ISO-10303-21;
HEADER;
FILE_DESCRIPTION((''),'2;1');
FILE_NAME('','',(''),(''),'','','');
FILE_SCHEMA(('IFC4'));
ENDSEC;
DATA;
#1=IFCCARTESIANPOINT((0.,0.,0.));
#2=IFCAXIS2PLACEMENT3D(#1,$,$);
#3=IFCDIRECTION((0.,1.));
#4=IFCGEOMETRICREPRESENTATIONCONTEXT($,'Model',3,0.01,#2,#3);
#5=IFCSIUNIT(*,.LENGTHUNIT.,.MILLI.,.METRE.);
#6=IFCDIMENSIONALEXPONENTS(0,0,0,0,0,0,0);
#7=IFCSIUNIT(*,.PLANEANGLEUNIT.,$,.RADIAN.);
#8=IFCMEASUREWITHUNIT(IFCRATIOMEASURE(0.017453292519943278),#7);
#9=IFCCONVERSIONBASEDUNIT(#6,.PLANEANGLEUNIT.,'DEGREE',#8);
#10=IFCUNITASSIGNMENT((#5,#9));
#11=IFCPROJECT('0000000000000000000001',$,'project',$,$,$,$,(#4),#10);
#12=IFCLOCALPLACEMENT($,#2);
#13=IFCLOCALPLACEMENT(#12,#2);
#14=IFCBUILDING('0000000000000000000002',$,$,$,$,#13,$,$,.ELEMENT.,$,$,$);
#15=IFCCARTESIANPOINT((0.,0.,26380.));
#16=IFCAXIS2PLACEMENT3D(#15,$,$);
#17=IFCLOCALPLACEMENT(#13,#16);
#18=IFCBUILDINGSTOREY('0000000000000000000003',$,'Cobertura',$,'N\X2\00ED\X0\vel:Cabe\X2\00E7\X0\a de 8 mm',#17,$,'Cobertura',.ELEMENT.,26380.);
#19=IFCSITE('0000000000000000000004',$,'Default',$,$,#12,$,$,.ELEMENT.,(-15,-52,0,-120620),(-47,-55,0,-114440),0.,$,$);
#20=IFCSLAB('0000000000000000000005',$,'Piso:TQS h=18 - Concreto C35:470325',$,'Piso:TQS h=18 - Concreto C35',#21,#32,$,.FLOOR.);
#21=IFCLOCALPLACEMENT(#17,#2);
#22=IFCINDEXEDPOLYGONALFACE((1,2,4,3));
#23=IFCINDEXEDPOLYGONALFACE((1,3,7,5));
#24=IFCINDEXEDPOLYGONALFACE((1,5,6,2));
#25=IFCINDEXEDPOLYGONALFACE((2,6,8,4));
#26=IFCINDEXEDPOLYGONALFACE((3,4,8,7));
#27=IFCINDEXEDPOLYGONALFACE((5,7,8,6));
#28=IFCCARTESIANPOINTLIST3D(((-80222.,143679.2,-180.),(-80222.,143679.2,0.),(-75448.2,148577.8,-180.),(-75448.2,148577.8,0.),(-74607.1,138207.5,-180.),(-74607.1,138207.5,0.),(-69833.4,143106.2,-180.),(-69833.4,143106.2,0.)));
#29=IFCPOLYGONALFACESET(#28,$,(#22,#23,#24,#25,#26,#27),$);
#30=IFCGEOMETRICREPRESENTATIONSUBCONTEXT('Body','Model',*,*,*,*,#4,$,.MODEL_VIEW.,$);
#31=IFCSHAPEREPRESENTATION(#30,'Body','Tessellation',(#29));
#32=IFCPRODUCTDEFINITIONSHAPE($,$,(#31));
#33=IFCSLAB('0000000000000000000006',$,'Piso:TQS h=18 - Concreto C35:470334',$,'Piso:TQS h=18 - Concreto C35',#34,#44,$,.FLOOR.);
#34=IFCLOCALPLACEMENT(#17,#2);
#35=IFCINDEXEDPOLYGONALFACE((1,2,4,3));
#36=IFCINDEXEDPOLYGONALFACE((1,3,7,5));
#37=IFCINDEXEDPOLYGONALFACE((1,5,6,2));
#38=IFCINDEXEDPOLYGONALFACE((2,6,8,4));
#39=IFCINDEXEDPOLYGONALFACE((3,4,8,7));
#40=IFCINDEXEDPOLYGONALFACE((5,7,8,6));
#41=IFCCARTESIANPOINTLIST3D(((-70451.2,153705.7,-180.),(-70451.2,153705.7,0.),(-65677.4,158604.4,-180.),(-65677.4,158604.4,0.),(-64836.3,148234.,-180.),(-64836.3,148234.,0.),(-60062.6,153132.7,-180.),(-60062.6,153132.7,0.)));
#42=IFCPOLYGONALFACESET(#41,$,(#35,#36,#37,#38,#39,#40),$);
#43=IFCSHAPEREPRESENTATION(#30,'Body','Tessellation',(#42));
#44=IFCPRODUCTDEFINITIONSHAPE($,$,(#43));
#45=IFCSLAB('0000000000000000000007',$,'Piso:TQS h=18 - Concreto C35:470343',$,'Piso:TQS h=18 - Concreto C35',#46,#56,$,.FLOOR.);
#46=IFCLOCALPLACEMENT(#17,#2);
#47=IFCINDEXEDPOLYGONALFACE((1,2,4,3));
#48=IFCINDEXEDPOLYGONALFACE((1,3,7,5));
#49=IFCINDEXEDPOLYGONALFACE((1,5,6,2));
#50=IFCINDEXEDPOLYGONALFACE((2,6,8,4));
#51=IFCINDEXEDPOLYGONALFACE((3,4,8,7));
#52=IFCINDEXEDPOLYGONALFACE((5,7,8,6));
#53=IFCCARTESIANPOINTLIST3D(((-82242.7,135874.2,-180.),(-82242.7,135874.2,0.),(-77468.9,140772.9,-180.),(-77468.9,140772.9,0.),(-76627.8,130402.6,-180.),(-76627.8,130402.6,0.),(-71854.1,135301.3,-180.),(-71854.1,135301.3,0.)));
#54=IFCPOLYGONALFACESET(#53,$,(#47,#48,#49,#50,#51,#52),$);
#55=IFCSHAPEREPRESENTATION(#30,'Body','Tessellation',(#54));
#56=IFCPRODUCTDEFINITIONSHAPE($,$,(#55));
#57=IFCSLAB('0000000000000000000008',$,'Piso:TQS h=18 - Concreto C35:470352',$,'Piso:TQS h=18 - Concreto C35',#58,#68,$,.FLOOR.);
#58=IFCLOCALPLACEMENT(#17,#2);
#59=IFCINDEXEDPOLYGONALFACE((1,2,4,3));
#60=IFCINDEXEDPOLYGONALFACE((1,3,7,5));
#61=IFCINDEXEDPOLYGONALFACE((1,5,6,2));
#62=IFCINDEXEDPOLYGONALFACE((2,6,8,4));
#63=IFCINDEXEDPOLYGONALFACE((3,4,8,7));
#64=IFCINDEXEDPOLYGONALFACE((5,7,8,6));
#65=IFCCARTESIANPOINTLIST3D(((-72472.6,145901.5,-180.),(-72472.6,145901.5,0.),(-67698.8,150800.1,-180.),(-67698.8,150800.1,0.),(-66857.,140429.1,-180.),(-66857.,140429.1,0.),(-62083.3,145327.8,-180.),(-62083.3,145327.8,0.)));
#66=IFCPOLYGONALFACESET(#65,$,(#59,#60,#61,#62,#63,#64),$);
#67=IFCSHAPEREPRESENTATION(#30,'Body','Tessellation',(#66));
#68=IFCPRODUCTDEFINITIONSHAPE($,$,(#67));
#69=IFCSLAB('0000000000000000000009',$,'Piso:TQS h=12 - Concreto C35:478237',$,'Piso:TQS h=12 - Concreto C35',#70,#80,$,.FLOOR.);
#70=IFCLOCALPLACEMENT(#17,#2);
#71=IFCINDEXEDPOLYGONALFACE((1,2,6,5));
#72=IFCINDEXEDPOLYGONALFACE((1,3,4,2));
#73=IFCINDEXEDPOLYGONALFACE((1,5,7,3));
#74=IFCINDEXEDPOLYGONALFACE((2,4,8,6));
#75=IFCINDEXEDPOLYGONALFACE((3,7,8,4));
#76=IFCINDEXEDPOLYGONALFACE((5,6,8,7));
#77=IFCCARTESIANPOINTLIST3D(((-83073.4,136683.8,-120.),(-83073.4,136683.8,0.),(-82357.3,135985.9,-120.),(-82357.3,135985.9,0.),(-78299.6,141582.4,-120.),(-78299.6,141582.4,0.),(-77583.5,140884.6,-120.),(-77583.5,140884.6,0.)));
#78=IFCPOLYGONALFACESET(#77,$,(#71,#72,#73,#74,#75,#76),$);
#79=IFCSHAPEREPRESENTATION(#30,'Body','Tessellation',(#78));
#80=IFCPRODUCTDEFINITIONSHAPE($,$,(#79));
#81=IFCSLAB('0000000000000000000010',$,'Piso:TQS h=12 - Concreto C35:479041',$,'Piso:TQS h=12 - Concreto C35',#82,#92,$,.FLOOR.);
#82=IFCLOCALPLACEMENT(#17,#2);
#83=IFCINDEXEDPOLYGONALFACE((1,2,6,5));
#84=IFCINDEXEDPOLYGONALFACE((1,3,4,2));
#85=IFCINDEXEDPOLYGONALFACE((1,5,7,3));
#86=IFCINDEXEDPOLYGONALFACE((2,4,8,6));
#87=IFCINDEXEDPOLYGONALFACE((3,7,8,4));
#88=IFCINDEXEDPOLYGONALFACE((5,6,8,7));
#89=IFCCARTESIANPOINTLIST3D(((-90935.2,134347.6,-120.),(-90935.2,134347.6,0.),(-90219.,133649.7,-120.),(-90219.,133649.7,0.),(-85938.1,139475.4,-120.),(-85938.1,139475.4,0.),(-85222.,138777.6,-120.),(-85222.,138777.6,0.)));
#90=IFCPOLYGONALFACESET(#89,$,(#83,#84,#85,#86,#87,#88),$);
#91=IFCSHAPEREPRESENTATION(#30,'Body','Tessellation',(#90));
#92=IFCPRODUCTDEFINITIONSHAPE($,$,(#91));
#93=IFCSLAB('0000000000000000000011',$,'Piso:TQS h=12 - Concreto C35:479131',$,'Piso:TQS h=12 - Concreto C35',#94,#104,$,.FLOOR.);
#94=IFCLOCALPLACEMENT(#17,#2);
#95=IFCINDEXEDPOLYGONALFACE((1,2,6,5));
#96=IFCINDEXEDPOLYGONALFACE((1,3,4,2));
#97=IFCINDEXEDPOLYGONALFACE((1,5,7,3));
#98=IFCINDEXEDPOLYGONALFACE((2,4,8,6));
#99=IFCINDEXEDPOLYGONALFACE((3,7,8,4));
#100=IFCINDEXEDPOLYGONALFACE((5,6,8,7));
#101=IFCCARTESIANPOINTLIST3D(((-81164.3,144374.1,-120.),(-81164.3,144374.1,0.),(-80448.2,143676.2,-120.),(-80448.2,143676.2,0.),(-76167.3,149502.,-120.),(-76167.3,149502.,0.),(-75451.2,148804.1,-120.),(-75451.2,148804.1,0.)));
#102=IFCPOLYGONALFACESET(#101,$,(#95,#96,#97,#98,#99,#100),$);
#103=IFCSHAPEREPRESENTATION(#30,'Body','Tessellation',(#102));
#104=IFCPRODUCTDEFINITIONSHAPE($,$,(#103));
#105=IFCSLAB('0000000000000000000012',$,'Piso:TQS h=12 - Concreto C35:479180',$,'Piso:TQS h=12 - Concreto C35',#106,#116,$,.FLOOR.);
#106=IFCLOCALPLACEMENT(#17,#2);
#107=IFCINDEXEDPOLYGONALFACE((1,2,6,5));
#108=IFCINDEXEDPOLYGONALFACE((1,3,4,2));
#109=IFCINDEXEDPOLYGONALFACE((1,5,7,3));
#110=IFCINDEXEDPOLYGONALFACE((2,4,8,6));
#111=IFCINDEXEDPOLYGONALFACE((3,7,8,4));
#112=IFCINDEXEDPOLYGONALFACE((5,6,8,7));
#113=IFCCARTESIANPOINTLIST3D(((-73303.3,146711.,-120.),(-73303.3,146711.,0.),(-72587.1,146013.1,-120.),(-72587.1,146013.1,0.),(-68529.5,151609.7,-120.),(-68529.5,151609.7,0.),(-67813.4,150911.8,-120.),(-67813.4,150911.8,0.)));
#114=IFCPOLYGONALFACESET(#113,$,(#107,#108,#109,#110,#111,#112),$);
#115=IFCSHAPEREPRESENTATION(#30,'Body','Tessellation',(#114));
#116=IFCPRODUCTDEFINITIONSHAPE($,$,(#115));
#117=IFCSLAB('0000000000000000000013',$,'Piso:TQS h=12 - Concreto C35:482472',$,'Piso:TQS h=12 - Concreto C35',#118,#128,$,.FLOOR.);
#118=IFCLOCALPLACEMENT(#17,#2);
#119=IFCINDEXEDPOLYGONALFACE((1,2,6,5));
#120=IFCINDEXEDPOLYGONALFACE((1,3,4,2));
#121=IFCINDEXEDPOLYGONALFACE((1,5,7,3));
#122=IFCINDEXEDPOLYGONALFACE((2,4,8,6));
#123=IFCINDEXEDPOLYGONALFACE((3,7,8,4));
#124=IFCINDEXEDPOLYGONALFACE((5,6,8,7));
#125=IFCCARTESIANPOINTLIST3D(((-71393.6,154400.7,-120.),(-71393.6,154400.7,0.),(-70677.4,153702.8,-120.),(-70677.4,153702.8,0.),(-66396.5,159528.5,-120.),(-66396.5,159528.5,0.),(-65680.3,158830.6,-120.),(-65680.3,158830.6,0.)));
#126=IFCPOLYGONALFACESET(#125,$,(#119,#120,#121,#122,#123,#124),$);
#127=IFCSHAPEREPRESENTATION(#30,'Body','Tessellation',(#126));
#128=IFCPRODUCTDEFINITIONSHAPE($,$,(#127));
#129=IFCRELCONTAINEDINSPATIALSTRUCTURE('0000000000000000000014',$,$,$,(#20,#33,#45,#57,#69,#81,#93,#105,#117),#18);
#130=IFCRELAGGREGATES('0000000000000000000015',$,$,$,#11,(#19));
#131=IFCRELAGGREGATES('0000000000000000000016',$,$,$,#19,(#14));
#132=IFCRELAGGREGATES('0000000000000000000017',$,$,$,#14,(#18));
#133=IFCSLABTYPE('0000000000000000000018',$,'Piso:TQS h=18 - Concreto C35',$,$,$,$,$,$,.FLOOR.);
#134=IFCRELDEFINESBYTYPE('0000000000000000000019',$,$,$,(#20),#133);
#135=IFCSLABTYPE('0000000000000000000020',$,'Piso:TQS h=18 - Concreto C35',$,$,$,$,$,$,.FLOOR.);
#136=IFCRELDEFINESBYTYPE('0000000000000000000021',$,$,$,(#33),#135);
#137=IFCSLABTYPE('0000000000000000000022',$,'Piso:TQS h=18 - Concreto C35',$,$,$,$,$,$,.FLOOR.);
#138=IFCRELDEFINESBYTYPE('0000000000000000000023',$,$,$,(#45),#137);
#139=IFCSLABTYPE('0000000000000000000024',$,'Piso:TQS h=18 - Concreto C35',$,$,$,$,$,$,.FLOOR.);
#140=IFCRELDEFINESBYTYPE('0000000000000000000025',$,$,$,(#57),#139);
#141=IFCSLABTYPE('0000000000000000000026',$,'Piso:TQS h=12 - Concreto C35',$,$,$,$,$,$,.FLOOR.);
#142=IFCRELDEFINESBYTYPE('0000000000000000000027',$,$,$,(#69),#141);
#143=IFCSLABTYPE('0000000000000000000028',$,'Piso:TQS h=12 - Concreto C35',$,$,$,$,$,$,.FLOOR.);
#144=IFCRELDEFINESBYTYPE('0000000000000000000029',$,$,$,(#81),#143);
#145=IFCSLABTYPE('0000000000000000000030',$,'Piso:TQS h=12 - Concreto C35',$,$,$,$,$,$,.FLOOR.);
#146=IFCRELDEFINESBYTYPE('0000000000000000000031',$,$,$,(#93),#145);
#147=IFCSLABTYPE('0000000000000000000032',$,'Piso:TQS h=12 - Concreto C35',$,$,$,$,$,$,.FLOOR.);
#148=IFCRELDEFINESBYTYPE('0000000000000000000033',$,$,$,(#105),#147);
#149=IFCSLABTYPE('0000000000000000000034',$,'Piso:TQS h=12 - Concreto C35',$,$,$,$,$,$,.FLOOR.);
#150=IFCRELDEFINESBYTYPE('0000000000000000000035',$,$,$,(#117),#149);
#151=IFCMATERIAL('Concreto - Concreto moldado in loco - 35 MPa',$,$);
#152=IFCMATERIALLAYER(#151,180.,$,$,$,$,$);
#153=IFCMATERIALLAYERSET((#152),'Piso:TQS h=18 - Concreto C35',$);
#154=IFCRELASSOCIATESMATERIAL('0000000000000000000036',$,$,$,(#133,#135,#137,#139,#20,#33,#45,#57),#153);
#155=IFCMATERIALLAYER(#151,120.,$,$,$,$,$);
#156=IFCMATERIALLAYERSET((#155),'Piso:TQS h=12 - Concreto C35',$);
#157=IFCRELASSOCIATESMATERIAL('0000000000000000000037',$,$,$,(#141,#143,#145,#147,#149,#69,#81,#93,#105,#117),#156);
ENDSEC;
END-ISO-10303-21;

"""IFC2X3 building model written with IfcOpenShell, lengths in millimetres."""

from ifc_helpers import new_model, entity, si_unit, converted_unit, direction, frame, frame_2d, origin, place, context, subcontext, project, spatial, rectangle, extrude, material, layer, layer_set, layer_usage, type_object, element, save


model = new_model("IFC2X3")

# Units and contexts
model_context = context("Model", 3, precision=0.01, world=origin(), true_north=direction((0.0, 1.0)))
body_context = subcontext(model_context, "Body", "Model", "MODEL_VIEW")
ifc_project = project(units=[si_unit("LENGTHUNIT", "METRE", prefix="MILLI"), converted_unit("PLANEANGLEUNIT", "DEGREE", entity("IfcRatioMeasure", 0.017453292519943278), si_unit("PLANEANGLEUNIT", "RADIAN"), dimensions=[0, 0, 0, 0, 0, 0, 0])], contexts=[model_context])

# Site, building, storey
site_placement = place(None, origin())
site = spatial("IfcSite", under=ifc_project, at=site_placement, Name="Default", CompositionType="ELEMENT", RefLatitude=(-15, -52, 0, -120620), RefLongitude=(-47, -55, 0, -114440), RefElevation=0.0)
building_placement = place(site_placement, origin())
building = spatial("IfcBuilding", under=site, at=building_placement, CompositionType="ELEMENT")
storey_placement = place(building_placement, frame((0.0, 0.0, 26380.0)))
storey = spatial("IfcBuildingStorey", under=building, at=storey_placement, Name="Cobertura", ObjectType="Nível:Cabeça de 8 mm", LongName="Cobertura", CompositionType="ELEMENT", Elevation=26380.0)

# Shared definitions
ifc_material = material(Name="Concreto - Concreto moldado in loco - 35 MPa")

# Slabs
ifc_layer_1 = layer(ifc_material, 180.0)
ifc_layer_set_1 = layer_set([ifc_layer_1], Name="Piso:TQS h=18 - Concreto C35")
ifc_layer_usage_1 = layer_usage(ifc_layer_set_1, "AXIS3", "POSITIVE", 0.0)
slab_type_1 = type_object("IfcSlabType", Name="Piso:TQS h=18 - Concreto C35", PredefinedType="FLOOR", material=ifc_layer_set_1)
slab_1_placement = place(storey_placement, origin())
element("IfcSlab", 1, at=slab_1_placement, inside=storey, type_object=slab_type_1, material=ifc_layer_usage_1, Name="Piso:TQS h=18 - Concreto C35:470325", ObjectType="Piso:TQS h=18 - Concreto C35", PredefinedType="FLOOR", context=body_context, shape_type="SweptSolid", body=[
    extrude(rectangle(XDim=6840.0, YDim=7840.0, at=frame_2d((0.0, 0.0), x_axis=(1.0, 0.0))), frame((-75027.7, 143392.7, 0.0), z_axis=(0.0, 0.0, -1.0), x_axis=(-0.697915, -0.71618, 0.0)), (0.0, 0.0, 1.0), 180.0),
])
ifc_layer_usage_2 = layer_usage(ifc_layer_set_1, "AXIS3", "POSITIVE", 0.0)
slab_type_2 = type_object("IfcSlabType", Name="Piso:TQS h=18 - Concreto C35", PredefinedType="FLOOR", material=ifc_layer_set_1)
slab_2_placement = place(storey_placement, origin())
element("IfcSlab", 2, at=slab_2_placement, inside=storey, type_object=slab_type_2, material=ifc_layer_usage_2, Name="Piso:TQS h=18 - Concreto C35:470334", ObjectType="Piso:TQS h=18 - Concreto C35", PredefinedType="FLOOR", context=body_context, shape_type="SweptSolid", body=[
    extrude(rectangle(XDim=7840.0, YDim=6840.0, at=frame_2d((0.0, 0.0), x_axis=(1.0, 0.0))), frame((-65256.9, 153419.2, 0.0), z_axis=(0.0, 0.0, -1.0), x_axis=(0.71618, -0.697915, 0.0)), (0.0, 0.0, 1.0), 180.0),
])
ifc_layer_usage_3 = layer_usage(ifc_layer_set_1, "AXIS3", "POSITIVE", 0.0)
slab_type_3 = type_object("IfcSlabType", Name="Piso:TQS h=18 - Concreto C35", PredefinedType="FLOOR", material=ifc_layer_set_1)
slab_3_placement = place(storey_placement, origin())
element("IfcSlab", 3, at=slab_3_placement, inside=storey, type_object=slab_type_3, material=ifc_layer_usage_3, Name="Piso:TQS h=18 - Concreto C35:470343", ObjectType="Piso:TQS h=18 - Concreto C35", PredefinedType="FLOOR", context=body_context, shape_type="SweptSolid", body=[
    extrude(rectangle(XDim=6840.0, YDim=7840.0, at=frame_2d((0.0, 0.0), x_axis=(1.0, 0.0))), frame((-77048.4, 135587.8, 0.0), z_axis=(0.0, 0.0, -1.0), x_axis=(-0.697915, -0.71618, 0.0)), (0.0, 0.0, 1.0), 180.0),
])
ifc_layer_usage_4 = layer_usage(ifc_layer_set_1, "AXIS3", "POSITIVE", 0.0)
slab_type_4 = type_object("IfcSlabType", Name="Piso:TQS h=18 - Concreto C35", PredefinedType="FLOOR", material=ifc_layer_set_1)
slab_4_placement = place(storey_placement, origin())
element("IfcSlab", 4, at=slab_4_placement, inside=storey, type_object=slab_type_4, material=ifc_layer_usage_4, Name="Piso:TQS h=18 - Concreto C35:470352", ObjectType="Piso:TQS h=18 - Concreto C35", PredefinedType="FLOOR", context=body_context, shape_type="SweptSolid", body=[
    extrude(rectangle(XDim=7841.0, YDim=6840.0, at=frame_2d((0.0, 0.0), x_axis=(1.0, 0.0))), frame((-67277.9, 145614.6, 0.0), z_axis=(0.0, 0.0, -1.0), x_axis=(0.71618, -0.697915, 0.0)), (0.0, 0.0, 1.0), 180.0),
])
ifc_layer_2 = layer(ifc_material, 120.0)
ifc_layer_set_2 = layer_set([ifc_layer_2], Name="Piso:TQS h=12 - Concreto C35")
ifc_layer_usage_5 = layer_usage(ifc_layer_set_2, "AXIS3", "POSITIVE", 0.0)
slab_type_5 = type_object("IfcSlabType", Name="Piso:TQS h=12 - Concreto C35", PredefinedType="FLOOR", material=ifc_layer_set_2)
slab_5_placement = place(storey_placement, origin())
element("IfcSlab", 5, at=slab_5_placement, inside=storey, type_object=slab_type_5, material=ifc_layer_usage_5, Name="Piso:TQS h=12 - Concreto C35:478237", ObjectType="Piso:TQS h=12 - Concreto C35", PredefinedType="FLOOR", context=body_context, shape_type="SweptSolid", body=[
    extrude(rectangle(XDim=6840.0, YDim=999.9, at=frame_2d((0.0, 0.0), x_axis=(1.0, 0.0))), frame((-80328.4, 138784.2, 0.0), z_axis=(0.0, 0.0, -1.0), x_axis=(-0.697915, -0.71618, 0.0)), (0.0, 0.0, 1.0), 120.0),
])
ifc_layer_usage_6 = layer_usage(ifc_layer_set_2, "AXIS3", "POSITIVE", 0.0)
slab_type_6 = type_object("IfcSlabType", Name="Piso:TQS h=12 - Concreto C35", PredefinedType="FLOOR", material=ifc_layer_set_2)
slab_6_placement = place(storey_placement, origin())
element("IfcSlab", 6, at=slab_6_placement, inside=storey, type_object=slab_type_6, material=ifc_layer_usage_6, Name="Piso:TQS h=12 - Concreto C35:479041", ObjectType="Piso:TQS h=12 - Concreto C35", PredefinedType="FLOOR", context=body_context, shape_type="SweptSolid", body=[
    extrude(rectangle(XDim=7160.0, YDim=999.9, at=frame_2d((0.0, 0.0), x_axis=(1.0, 0.0))), frame((-88078.6, 136562.6, 0.0), z_axis=(0.0, 0.0, -1.0), x_axis=(-0.697915, -0.71618, 0.0)), (0.0, 0.0, 1.0), 120.0),
])
ifc_layer_usage_7 = layer_usage(ifc_layer_set_2, "AXIS3", "POSITIVE", 0.0)
slab_type_7 = type_object("IfcSlabType", Name="Piso:TQS h=12 - Concreto C35", PredefinedType="FLOOR", material=ifc_layer_set_2)
slab_7_placement = place(storey_placement, origin())
element("IfcSlab", 7, at=slab_7_placement, inside=storey, type_object=slab_type_7, material=ifc_layer_usage_7, Name="Piso:TQS h=12 - Concreto C35:479131", ObjectType="Piso:TQS h=12 - Concreto C35", PredefinedType="FLOOR", context=body_context, shape_type="SweptSolid", body=[
    extrude(rectangle(XDim=7160.0, YDim=999.9, at=frame_2d((0.0, 0.0), x_axis=(1.0, 0.0))), frame((-78307.8, 146589.1, 0.0), z_axis=(0.0, 0.0, -1.0), x_axis=(-0.697915, -0.71618, 0.0)), (0.0, 0.0, 1.0), 120.0),
])
ifc_layer_usage_8 = layer_usage(ifc_layer_set_2, "AXIS3", "POSITIVE", 0.0)
slab_type_8 = type_object("IfcSlabType", Name="Piso:TQS h=12 - Concreto C35", PredefinedType="FLOOR", material=ifc_layer_set_2)
slab_8_placement = place(storey_placement, origin())
element("IfcSlab", 8, at=slab_8_placement, inside=storey, type_object=slab_type_8, material=ifc_layer_usage_8, Name="Piso:TQS h=12 - Concreto C35:479180", ObjectType="Piso:TQS h=12 - Concreto C35", PredefinedType="FLOOR", context=body_context, shape_type="SweptSolid", body=[
    extrude(rectangle(XDim=6840.0, YDim=999.9, at=frame_2d((0.0, 0.0), x_axis=(1.0, 0.0))), frame((-70558.3, 148811.4, 0.0), z_axis=(0.0, 0.0, -1.0), x_axis=(-0.697915, -0.71618, 0.0)), (0.0, 0.0, 1.0), 120.0),
])
ifc_layer_usage_9 = layer_usage(ifc_layer_set_2, "AXIS3", "POSITIVE", 0.0)
slab_type_9 = type_object("IfcSlabType", Name="Piso:TQS h=12 - Concreto C35", PredefinedType="FLOOR", material=ifc_layer_set_2)
slab_9_placement = place(storey_placement, origin())
element("IfcSlab", 9, at=slab_9_placement, inside=storey, type_object=slab_type_9, material=ifc_layer_usage_9, Name="Piso:TQS h=12 - Concreto C35:482472", ObjectType="Piso:TQS h=12 - Concreto C35", PredefinedType="FLOOR", context=body_context, shape_type="SweptSolid", body=[
    extrude(rectangle(XDim=7160.0, YDim=1000.0, at=frame_2d((0.0, 0.0), x_axis=(1.0, 0.0))), frame((-68537.0, 156615.6, 0.0), z_axis=(0.0, 0.0, -1.0), x_axis=(-0.697915, -0.71618, 0.0)), (0.0, 0.0, 1.0), 120.0),
])

save(model, "model.ifc")
